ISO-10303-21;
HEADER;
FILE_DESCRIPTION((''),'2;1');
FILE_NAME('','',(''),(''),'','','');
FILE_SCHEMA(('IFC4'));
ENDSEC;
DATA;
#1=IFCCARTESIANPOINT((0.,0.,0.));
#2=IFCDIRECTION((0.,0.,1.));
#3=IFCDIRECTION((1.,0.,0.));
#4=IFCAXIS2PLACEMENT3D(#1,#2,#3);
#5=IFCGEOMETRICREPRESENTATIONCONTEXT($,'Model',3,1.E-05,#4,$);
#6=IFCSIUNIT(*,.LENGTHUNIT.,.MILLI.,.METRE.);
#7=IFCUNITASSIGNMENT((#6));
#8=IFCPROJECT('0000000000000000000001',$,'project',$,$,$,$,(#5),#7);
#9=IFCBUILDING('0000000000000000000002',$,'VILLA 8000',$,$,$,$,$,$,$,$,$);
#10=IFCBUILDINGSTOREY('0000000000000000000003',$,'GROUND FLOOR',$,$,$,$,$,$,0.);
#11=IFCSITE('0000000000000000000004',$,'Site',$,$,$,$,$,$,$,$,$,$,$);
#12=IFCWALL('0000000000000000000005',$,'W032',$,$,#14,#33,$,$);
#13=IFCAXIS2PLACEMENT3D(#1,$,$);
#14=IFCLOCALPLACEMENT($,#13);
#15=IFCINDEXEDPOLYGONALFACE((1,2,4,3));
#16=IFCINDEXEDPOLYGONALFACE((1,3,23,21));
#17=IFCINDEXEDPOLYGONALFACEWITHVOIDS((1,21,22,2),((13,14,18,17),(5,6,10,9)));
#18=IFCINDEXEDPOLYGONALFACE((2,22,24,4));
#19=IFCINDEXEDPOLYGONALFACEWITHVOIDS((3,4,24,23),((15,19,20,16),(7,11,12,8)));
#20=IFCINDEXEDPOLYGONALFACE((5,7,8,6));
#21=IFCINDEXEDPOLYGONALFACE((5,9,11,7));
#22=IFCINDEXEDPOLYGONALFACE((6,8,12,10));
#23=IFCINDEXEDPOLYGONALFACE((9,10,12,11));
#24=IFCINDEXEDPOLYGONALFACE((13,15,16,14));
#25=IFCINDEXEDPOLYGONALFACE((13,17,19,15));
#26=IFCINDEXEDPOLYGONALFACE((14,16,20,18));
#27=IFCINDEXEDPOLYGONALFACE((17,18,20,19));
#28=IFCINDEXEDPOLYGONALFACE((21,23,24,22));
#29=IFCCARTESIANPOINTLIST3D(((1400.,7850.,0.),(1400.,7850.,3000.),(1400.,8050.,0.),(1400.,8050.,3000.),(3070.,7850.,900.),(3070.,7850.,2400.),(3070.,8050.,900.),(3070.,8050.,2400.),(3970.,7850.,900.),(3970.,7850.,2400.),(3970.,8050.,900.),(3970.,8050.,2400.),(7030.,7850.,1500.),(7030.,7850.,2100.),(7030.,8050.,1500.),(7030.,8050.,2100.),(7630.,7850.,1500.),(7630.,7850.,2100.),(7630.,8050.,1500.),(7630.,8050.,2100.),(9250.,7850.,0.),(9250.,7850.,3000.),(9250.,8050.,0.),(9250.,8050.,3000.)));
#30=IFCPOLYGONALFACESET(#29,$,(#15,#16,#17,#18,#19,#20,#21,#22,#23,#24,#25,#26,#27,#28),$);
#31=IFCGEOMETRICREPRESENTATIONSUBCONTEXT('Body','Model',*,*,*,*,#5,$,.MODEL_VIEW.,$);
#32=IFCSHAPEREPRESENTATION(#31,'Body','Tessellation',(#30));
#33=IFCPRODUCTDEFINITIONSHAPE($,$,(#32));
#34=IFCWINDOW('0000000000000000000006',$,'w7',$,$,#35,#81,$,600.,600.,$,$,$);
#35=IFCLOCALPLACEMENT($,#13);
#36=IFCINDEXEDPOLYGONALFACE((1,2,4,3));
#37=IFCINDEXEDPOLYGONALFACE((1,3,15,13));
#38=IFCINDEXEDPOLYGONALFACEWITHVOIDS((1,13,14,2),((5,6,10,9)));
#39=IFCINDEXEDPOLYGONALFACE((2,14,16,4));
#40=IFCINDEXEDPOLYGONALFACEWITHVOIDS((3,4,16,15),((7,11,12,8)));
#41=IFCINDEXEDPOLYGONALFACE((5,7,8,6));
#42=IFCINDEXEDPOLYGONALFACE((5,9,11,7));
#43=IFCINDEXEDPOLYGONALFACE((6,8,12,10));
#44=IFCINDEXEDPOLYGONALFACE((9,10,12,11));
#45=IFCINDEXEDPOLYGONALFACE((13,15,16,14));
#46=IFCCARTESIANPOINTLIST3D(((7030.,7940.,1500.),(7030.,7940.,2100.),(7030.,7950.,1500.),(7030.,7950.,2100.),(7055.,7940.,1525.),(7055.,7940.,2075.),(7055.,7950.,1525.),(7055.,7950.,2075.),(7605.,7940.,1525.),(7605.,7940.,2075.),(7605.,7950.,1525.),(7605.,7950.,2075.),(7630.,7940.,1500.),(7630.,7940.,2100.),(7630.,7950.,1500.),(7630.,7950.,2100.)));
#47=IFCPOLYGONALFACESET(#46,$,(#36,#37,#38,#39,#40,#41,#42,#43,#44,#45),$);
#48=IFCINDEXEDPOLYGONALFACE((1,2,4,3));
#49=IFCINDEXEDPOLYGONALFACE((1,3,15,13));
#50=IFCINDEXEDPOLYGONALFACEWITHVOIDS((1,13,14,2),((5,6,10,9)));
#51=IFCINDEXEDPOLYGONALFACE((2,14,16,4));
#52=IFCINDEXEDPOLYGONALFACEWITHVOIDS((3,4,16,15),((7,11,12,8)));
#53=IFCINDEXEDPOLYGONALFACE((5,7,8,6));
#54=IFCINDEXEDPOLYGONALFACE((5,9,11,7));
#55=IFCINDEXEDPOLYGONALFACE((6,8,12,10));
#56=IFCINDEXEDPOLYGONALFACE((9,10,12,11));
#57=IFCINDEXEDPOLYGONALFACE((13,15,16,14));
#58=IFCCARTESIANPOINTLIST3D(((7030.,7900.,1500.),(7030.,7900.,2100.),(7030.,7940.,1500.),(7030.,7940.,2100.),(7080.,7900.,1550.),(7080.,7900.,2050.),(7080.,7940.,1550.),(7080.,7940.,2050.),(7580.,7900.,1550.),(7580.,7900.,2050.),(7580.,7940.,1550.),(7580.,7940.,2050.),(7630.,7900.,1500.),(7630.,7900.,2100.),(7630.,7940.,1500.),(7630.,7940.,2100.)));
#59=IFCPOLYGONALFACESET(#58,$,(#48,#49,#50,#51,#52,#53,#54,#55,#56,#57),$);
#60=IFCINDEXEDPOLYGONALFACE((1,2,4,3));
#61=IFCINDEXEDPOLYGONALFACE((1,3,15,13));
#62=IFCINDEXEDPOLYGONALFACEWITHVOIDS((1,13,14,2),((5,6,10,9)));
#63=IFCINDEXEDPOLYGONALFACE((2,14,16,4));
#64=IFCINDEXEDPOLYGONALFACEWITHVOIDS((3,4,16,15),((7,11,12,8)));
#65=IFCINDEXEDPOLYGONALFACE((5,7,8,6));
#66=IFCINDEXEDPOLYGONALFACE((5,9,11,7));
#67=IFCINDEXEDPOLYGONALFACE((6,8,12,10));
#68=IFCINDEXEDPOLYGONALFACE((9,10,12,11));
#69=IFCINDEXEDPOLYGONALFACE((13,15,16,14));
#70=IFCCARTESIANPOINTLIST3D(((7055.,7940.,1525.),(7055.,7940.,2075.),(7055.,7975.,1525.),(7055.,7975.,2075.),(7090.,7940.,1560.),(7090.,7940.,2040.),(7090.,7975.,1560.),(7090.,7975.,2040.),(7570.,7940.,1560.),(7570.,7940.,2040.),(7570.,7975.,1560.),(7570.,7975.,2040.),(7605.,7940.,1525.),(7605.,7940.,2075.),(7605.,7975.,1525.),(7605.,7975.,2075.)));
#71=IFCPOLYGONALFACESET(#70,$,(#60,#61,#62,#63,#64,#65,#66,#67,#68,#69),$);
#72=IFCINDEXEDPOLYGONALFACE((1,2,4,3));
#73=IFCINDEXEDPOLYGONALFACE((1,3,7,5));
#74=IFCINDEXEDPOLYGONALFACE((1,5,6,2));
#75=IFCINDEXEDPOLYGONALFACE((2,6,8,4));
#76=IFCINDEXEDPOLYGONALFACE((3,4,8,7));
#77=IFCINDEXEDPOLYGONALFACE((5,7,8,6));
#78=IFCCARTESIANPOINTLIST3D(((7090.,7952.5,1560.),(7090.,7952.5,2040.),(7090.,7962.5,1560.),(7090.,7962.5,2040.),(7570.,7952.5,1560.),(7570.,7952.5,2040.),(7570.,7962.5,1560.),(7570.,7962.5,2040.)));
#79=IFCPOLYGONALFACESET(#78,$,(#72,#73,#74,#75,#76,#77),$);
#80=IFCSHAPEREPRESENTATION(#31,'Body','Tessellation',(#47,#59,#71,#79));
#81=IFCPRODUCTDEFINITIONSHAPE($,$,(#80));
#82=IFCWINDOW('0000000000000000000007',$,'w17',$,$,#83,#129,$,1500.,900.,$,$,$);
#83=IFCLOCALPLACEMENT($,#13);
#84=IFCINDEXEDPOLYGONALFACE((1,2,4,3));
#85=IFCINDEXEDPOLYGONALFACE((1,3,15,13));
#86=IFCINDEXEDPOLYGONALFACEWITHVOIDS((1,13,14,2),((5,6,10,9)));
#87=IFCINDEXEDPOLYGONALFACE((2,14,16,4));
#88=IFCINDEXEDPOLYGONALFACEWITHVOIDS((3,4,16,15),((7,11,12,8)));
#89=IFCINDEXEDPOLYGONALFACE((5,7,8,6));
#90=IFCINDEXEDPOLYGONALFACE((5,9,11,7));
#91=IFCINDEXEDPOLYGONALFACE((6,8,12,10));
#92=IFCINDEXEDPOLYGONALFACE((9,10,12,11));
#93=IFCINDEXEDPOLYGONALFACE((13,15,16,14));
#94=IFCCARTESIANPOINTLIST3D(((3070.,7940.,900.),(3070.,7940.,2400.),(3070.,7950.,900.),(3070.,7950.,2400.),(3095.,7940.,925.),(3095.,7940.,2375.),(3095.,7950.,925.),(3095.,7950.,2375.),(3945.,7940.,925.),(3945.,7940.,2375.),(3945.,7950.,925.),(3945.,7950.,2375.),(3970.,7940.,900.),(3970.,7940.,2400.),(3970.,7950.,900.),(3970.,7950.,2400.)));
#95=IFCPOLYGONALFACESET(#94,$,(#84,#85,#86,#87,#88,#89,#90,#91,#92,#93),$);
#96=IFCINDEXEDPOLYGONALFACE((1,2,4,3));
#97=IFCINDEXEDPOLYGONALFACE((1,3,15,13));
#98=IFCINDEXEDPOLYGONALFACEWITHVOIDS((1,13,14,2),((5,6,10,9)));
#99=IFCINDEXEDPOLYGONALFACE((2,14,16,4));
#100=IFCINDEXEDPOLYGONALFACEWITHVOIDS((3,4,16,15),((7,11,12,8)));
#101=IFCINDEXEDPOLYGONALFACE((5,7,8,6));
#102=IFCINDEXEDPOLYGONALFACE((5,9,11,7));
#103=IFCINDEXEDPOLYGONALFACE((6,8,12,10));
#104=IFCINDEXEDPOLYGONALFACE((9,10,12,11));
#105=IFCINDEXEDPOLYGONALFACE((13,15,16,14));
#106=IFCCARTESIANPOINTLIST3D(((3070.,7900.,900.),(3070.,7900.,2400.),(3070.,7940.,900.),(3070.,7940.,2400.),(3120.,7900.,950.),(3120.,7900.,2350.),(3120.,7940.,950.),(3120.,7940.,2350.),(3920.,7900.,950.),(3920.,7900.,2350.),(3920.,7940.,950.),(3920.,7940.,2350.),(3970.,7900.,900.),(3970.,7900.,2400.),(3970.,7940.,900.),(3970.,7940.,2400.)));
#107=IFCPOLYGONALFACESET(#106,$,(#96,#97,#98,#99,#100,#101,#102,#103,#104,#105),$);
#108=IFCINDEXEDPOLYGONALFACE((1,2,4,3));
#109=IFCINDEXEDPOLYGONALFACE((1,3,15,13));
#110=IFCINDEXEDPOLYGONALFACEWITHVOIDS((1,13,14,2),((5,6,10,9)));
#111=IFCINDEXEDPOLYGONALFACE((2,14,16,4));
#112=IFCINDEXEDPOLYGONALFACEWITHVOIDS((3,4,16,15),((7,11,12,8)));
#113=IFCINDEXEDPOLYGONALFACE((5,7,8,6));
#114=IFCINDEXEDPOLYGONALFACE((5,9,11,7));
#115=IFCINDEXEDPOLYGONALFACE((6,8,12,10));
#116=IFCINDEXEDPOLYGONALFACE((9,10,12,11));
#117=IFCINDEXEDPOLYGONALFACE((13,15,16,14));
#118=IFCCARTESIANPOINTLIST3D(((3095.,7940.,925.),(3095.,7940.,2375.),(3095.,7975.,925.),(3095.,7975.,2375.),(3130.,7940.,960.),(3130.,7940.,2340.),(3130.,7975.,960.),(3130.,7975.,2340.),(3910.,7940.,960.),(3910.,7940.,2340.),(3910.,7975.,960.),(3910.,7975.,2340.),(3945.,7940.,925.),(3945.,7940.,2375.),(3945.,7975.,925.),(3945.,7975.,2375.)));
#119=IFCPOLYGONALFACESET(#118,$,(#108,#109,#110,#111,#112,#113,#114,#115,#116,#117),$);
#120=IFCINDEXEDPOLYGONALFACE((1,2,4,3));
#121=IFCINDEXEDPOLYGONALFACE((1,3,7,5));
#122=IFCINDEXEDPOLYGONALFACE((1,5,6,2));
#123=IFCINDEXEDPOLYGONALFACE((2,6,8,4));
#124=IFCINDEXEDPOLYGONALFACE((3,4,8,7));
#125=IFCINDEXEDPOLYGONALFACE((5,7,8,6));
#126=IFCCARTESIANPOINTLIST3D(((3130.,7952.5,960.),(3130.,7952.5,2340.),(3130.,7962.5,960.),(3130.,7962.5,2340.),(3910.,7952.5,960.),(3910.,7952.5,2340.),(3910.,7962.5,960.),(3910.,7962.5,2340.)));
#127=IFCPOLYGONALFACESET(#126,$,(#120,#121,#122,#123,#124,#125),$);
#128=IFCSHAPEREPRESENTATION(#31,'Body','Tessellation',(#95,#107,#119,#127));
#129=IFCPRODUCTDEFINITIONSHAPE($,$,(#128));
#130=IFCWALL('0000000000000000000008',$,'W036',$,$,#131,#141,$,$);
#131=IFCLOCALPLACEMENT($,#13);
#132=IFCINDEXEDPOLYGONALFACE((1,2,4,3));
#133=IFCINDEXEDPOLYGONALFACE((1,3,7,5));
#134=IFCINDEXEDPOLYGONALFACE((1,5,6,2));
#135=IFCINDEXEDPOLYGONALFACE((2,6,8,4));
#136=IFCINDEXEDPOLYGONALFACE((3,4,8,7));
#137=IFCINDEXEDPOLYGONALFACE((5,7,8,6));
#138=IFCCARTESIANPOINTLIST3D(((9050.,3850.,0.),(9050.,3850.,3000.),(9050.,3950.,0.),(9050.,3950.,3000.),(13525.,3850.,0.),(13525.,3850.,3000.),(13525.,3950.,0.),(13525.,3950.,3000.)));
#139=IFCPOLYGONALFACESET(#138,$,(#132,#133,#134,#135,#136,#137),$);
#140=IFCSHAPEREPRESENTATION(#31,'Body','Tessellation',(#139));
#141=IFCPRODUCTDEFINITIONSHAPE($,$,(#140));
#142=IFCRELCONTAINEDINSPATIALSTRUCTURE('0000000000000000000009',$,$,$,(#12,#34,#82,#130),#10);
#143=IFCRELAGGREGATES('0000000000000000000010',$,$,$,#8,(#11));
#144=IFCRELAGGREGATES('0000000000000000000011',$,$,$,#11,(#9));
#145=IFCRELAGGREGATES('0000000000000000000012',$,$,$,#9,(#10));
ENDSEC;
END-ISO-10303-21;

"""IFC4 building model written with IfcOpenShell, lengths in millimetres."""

from ifc_helpers import new_model, si_unit, frame, origin_with_axes, place, context, subcontext, project, spatial, line, indexed_curve, outline, extrude, element, fill, save


model = new_model("IFC4")

# Units and contexts
model_context = context("Model", 3, precision=1e-05, world=origin_with_axes())
body_context = subcontext(model_context, "Body", "Model", "MODEL_VIEW")
ifc_project = project(units=[si_unit("LENGTHUNIT", "METRE", prefix="MILLI")], contexts=[model_context])

# Site, building, storey
site = spatial("IfcSite", under=ifc_project, Name="Site")
building = spatial("IfcBuilding", under=site, Name="VILLA 8000")
storey = spatial("IfcBuildingStorey", under=building, Name="GROUND FLOOR", Elevation=0.0)

# Wall, openings, windows
wall_1_placement = place(None, frame((1400.0, 7950.0, 0.0), z_axis=(0.0, 0.0, 1.0), x_axis=(1.0, 0.0, 0.0)))
wall_1 = element("IfcWall", 1, at=wall_1_placement, inside=storey, Name="W032", context=body_context, shape_type="SweptSolid", body=[
    extrude(outline(indexed_curve([(0.0, 0.0), (0.0, 200.0), (7850.0, 200.0), (7850.0, 0.0), (0.0, 0.0)], self_intersect=False)), frame((0.0, -100.0, 0.0), z_axis=(0.0, 0.0, 1.0), x_axis=(1.0, 0.0, 0.0)), (0.0, 0.0, 1.0), 3000.0),
])
opening_1_placement = place(wall_1_placement, frame((5630.0, 0.0, 1500.0), z_axis=(0.0, 0.0, 1.0), x_axis=(1.0, 0.0, 0.0)))
opening_1 = element("IfcOpeningElement", 2, at=opening_1_placement, cuts=wall_1, context=body_context, shape_type="SweptSolid", body=[
    extrude(outline(indexed_curve([(0.0, 0.0), (0.0, 300.0), (600.0, 300.0), (600.0, 0.0), (0.0, 0.0)], self_intersect=False)), frame((0.0, -150.0, 0.0), z_axis=(0.0, 0.0, 1.0), x_axis=(1.0, 0.0, 0.0)), (0.0, 0.0, 1.0), 600.0),
])
opening_2_placement = place(wall_1_placement, frame((1670.0, 0.0, 900.0), z_axis=(0.0, 0.0, 1.0), x_axis=(1.0, 0.0, 0.0)))
opening_2 = element("IfcOpeningElement", 3, at=opening_2_placement, cuts=wall_1, context=body_context, shape_type="SweptSolid", body=[
    extrude(outline(indexed_curve([(0.0, 0.0), (0.0, 300.0), (900.0, 300.0), (900.0, 0.0), (0.0, 0.0)], self_intersect=False)), frame((0.0, -150.0, 0.0), z_axis=(0.0, 0.0, 1.0), x_axis=(1.0, 0.0, 0.0)), (0.0, 0.0, 1.0), 1500.0),
])
window_1_placement = place(None, frame((7030.0, 7850.0, 1500.0), z_axis=(0.0, 0.0, 1.0), x_axis=(1.0, 0.0, 0.0)))
window_1 = element("IfcWindow", 4, at=window_1_placement, inside=storey, Name="w7", OverallHeight=600.0, OverallWidth=600.0, context=body_context, shape_type="SweptSolid", body=[
    extrude(outline(indexed_curve([(0.0, 0.0), (600.0, 0.0), (600.0, 600.0), (0.0, 600.0)], segments=[line(1, 2, 3, 4, 1)]), holes=[indexed_curve([(25.0, 25.0), (575.0, 25.0), (575.0, 575.0), (25.0, 575.0)], segments=[line(1, 2, 3, 4, 1)])]), frame((0.0, 90.0, 0.0), z_axis=(0.0, -1.0, 0.0), x_axis=(1.0, 0.0, 0.0)), (0.0, 0.0, -1.0), 10.0),
    extrude(outline(indexed_curve([(0.0, 0.0), (600.0, 0.0), (600.0, 600.0), (0.0, 600.0)], segments=[line(1, 2, 3, 4, 1)]), holes=[indexed_curve([(50.0, 50.0), (550.0, 50.0), (550.0, 550.0), (50.0, 550.0)], segments=[line(1, 2, 3, 4, 1)])]), frame((0.0, 50.0, 0.0), z_axis=(0.0, -1.0, 0.0), x_axis=(1.0, 0.0, 0.0)), (0.0, 0.0, -1.0), 40.0),
    extrude(outline(indexed_curve([(0.0, 0.0), (550.0, 0.0), (550.0, 550.0), (0.0, 550.0)], segments=[line(1, 2, 3, 4, 1)]), holes=[indexed_curve([(35.0, 35.0), (515.0, 35.0), (515.0, 515.0), (35.0, 515.0)], segments=[line(1, 2, 3, 4, 1)])]), frame((25.0, 90.0, 25.0), z_axis=(0.0, -1.0, 0.0), x_axis=(1.0, 0.0, 0.0)), (0.0, 0.0, -1.0), 35.0),
    extrude(outline(indexed_curve([(35.0, 35.0), (515.0, 35.0), (515.0, 515.0), (35.0, 515.0)], segments=[line(1, 2, 3, 4, 1)])), frame((25.0, 102.5, 25.0), z_axis=(0.0, -1.0, 0.0), x_axis=(1.0, 0.0, 0.0)), (0.0, 0.0, -1.0), 10.0),
])
fill(opening_1, window_1)
window_2_placement = place(None, frame((3070.0, 7850.0, 900.0), z_axis=(0.0, 0.0, 1.0), x_axis=(1.0, 0.0, 0.0)))
window_2 = element("IfcWindow", 5, at=window_2_placement, inside=storey, Name="w17", OverallHeight=1500.0, OverallWidth=900.0, context=body_context, shape_type="SweptSolid", body=[
    extrude(outline(indexed_curve([(0.0, 0.0), (900.0, 0.0), (900.0, 1500.0), (0.0, 1500.0)], segments=[line(1, 2, 3, 4, 1)]), holes=[indexed_curve([(25.0, 25.0), (875.0, 25.0), (875.0, 1475.0), (25.0, 1475.0)], segments=[line(1, 2, 3, 4, 1)])]), frame((0.0, 90.0, 0.0), z_axis=(0.0, -1.0, 0.0), x_axis=(1.0, 0.0, 0.0)), (0.0, 0.0, -1.0), 10.0),
    extrude(outline(indexed_curve([(0.0, 0.0), (900.0, 0.0), (900.0, 1500.0), (0.0, 1500.0)], segments=[line(1, 2, 3, 4, 1)]), holes=[indexed_curve([(50.0, 50.0), (850.0, 50.0), (850.0, 1450.0), (50.0, 1450.0)], segments=[line(1, 2, 3, 4, 1)])]), frame((0.0, 50.0, 0.0), z_axis=(0.0, -1.0, 0.0), x_axis=(1.0, 0.0, 0.0)), (0.0, 0.0, -1.0), 40.0),
    extrude(outline(indexed_curve([(0.0, 0.0), (850.0, 0.0), (850.0, 1450.0), (0.0, 1450.0)], segments=[line(1, 2, 3, 4, 1)]), holes=[indexed_curve([(35.0, 35.0), (815.0, 35.0), (815.0, 1415.0), (35.0, 1415.0)], segments=[line(1, 2, 3, 4, 1)])]), frame((25.0, 90.0, 25.0), z_axis=(0.0, -1.0, 0.0), x_axis=(1.0, 0.0, 0.0)), (0.0, 0.0, -1.0), 35.0),
    extrude(outline(indexed_curve([(35.0, 35.0), (815.0, 35.0), (815.0, 1415.0), (35.0, 1415.0)], segments=[line(1, 2, 3, 4, 1)])), frame((25.0, 102.5, 25.0), z_axis=(0.0, -1.0, 0.0), x_axis=(1.0, 0.0, 0.0)), (0.0, 0.0, -1.0), 10.0),
])
fill(opening_2, window_2)

# Wall
wall_2_placement = place(None, frame((9050.0, 3900.0, 0.0), z_axis=(0.0, 0.0, 1.0), x_axis=(1.0, 0.0, 0.0)))
element("IfcWall", 6, at=wall_2_placement, inside=storey, Name="W036", context=body_context, shape_type="SweptSolid", body=[
    extrude(outline(indexed_curve([(0.0, 0.0), (0.0, 100.0), (4475.0, 100.0), (4475.0, 0.0), (0.0, 0.0)], self_intersect=False)), frame((0.0, -50.0, 0.0), z_axis=(0.0, 0.0, 1.0), x_axis=(1.0, 0.0, 0.0)), (0.0, 0.0, 1.0), 3000.0),
])

save(model, "model.ifc")
